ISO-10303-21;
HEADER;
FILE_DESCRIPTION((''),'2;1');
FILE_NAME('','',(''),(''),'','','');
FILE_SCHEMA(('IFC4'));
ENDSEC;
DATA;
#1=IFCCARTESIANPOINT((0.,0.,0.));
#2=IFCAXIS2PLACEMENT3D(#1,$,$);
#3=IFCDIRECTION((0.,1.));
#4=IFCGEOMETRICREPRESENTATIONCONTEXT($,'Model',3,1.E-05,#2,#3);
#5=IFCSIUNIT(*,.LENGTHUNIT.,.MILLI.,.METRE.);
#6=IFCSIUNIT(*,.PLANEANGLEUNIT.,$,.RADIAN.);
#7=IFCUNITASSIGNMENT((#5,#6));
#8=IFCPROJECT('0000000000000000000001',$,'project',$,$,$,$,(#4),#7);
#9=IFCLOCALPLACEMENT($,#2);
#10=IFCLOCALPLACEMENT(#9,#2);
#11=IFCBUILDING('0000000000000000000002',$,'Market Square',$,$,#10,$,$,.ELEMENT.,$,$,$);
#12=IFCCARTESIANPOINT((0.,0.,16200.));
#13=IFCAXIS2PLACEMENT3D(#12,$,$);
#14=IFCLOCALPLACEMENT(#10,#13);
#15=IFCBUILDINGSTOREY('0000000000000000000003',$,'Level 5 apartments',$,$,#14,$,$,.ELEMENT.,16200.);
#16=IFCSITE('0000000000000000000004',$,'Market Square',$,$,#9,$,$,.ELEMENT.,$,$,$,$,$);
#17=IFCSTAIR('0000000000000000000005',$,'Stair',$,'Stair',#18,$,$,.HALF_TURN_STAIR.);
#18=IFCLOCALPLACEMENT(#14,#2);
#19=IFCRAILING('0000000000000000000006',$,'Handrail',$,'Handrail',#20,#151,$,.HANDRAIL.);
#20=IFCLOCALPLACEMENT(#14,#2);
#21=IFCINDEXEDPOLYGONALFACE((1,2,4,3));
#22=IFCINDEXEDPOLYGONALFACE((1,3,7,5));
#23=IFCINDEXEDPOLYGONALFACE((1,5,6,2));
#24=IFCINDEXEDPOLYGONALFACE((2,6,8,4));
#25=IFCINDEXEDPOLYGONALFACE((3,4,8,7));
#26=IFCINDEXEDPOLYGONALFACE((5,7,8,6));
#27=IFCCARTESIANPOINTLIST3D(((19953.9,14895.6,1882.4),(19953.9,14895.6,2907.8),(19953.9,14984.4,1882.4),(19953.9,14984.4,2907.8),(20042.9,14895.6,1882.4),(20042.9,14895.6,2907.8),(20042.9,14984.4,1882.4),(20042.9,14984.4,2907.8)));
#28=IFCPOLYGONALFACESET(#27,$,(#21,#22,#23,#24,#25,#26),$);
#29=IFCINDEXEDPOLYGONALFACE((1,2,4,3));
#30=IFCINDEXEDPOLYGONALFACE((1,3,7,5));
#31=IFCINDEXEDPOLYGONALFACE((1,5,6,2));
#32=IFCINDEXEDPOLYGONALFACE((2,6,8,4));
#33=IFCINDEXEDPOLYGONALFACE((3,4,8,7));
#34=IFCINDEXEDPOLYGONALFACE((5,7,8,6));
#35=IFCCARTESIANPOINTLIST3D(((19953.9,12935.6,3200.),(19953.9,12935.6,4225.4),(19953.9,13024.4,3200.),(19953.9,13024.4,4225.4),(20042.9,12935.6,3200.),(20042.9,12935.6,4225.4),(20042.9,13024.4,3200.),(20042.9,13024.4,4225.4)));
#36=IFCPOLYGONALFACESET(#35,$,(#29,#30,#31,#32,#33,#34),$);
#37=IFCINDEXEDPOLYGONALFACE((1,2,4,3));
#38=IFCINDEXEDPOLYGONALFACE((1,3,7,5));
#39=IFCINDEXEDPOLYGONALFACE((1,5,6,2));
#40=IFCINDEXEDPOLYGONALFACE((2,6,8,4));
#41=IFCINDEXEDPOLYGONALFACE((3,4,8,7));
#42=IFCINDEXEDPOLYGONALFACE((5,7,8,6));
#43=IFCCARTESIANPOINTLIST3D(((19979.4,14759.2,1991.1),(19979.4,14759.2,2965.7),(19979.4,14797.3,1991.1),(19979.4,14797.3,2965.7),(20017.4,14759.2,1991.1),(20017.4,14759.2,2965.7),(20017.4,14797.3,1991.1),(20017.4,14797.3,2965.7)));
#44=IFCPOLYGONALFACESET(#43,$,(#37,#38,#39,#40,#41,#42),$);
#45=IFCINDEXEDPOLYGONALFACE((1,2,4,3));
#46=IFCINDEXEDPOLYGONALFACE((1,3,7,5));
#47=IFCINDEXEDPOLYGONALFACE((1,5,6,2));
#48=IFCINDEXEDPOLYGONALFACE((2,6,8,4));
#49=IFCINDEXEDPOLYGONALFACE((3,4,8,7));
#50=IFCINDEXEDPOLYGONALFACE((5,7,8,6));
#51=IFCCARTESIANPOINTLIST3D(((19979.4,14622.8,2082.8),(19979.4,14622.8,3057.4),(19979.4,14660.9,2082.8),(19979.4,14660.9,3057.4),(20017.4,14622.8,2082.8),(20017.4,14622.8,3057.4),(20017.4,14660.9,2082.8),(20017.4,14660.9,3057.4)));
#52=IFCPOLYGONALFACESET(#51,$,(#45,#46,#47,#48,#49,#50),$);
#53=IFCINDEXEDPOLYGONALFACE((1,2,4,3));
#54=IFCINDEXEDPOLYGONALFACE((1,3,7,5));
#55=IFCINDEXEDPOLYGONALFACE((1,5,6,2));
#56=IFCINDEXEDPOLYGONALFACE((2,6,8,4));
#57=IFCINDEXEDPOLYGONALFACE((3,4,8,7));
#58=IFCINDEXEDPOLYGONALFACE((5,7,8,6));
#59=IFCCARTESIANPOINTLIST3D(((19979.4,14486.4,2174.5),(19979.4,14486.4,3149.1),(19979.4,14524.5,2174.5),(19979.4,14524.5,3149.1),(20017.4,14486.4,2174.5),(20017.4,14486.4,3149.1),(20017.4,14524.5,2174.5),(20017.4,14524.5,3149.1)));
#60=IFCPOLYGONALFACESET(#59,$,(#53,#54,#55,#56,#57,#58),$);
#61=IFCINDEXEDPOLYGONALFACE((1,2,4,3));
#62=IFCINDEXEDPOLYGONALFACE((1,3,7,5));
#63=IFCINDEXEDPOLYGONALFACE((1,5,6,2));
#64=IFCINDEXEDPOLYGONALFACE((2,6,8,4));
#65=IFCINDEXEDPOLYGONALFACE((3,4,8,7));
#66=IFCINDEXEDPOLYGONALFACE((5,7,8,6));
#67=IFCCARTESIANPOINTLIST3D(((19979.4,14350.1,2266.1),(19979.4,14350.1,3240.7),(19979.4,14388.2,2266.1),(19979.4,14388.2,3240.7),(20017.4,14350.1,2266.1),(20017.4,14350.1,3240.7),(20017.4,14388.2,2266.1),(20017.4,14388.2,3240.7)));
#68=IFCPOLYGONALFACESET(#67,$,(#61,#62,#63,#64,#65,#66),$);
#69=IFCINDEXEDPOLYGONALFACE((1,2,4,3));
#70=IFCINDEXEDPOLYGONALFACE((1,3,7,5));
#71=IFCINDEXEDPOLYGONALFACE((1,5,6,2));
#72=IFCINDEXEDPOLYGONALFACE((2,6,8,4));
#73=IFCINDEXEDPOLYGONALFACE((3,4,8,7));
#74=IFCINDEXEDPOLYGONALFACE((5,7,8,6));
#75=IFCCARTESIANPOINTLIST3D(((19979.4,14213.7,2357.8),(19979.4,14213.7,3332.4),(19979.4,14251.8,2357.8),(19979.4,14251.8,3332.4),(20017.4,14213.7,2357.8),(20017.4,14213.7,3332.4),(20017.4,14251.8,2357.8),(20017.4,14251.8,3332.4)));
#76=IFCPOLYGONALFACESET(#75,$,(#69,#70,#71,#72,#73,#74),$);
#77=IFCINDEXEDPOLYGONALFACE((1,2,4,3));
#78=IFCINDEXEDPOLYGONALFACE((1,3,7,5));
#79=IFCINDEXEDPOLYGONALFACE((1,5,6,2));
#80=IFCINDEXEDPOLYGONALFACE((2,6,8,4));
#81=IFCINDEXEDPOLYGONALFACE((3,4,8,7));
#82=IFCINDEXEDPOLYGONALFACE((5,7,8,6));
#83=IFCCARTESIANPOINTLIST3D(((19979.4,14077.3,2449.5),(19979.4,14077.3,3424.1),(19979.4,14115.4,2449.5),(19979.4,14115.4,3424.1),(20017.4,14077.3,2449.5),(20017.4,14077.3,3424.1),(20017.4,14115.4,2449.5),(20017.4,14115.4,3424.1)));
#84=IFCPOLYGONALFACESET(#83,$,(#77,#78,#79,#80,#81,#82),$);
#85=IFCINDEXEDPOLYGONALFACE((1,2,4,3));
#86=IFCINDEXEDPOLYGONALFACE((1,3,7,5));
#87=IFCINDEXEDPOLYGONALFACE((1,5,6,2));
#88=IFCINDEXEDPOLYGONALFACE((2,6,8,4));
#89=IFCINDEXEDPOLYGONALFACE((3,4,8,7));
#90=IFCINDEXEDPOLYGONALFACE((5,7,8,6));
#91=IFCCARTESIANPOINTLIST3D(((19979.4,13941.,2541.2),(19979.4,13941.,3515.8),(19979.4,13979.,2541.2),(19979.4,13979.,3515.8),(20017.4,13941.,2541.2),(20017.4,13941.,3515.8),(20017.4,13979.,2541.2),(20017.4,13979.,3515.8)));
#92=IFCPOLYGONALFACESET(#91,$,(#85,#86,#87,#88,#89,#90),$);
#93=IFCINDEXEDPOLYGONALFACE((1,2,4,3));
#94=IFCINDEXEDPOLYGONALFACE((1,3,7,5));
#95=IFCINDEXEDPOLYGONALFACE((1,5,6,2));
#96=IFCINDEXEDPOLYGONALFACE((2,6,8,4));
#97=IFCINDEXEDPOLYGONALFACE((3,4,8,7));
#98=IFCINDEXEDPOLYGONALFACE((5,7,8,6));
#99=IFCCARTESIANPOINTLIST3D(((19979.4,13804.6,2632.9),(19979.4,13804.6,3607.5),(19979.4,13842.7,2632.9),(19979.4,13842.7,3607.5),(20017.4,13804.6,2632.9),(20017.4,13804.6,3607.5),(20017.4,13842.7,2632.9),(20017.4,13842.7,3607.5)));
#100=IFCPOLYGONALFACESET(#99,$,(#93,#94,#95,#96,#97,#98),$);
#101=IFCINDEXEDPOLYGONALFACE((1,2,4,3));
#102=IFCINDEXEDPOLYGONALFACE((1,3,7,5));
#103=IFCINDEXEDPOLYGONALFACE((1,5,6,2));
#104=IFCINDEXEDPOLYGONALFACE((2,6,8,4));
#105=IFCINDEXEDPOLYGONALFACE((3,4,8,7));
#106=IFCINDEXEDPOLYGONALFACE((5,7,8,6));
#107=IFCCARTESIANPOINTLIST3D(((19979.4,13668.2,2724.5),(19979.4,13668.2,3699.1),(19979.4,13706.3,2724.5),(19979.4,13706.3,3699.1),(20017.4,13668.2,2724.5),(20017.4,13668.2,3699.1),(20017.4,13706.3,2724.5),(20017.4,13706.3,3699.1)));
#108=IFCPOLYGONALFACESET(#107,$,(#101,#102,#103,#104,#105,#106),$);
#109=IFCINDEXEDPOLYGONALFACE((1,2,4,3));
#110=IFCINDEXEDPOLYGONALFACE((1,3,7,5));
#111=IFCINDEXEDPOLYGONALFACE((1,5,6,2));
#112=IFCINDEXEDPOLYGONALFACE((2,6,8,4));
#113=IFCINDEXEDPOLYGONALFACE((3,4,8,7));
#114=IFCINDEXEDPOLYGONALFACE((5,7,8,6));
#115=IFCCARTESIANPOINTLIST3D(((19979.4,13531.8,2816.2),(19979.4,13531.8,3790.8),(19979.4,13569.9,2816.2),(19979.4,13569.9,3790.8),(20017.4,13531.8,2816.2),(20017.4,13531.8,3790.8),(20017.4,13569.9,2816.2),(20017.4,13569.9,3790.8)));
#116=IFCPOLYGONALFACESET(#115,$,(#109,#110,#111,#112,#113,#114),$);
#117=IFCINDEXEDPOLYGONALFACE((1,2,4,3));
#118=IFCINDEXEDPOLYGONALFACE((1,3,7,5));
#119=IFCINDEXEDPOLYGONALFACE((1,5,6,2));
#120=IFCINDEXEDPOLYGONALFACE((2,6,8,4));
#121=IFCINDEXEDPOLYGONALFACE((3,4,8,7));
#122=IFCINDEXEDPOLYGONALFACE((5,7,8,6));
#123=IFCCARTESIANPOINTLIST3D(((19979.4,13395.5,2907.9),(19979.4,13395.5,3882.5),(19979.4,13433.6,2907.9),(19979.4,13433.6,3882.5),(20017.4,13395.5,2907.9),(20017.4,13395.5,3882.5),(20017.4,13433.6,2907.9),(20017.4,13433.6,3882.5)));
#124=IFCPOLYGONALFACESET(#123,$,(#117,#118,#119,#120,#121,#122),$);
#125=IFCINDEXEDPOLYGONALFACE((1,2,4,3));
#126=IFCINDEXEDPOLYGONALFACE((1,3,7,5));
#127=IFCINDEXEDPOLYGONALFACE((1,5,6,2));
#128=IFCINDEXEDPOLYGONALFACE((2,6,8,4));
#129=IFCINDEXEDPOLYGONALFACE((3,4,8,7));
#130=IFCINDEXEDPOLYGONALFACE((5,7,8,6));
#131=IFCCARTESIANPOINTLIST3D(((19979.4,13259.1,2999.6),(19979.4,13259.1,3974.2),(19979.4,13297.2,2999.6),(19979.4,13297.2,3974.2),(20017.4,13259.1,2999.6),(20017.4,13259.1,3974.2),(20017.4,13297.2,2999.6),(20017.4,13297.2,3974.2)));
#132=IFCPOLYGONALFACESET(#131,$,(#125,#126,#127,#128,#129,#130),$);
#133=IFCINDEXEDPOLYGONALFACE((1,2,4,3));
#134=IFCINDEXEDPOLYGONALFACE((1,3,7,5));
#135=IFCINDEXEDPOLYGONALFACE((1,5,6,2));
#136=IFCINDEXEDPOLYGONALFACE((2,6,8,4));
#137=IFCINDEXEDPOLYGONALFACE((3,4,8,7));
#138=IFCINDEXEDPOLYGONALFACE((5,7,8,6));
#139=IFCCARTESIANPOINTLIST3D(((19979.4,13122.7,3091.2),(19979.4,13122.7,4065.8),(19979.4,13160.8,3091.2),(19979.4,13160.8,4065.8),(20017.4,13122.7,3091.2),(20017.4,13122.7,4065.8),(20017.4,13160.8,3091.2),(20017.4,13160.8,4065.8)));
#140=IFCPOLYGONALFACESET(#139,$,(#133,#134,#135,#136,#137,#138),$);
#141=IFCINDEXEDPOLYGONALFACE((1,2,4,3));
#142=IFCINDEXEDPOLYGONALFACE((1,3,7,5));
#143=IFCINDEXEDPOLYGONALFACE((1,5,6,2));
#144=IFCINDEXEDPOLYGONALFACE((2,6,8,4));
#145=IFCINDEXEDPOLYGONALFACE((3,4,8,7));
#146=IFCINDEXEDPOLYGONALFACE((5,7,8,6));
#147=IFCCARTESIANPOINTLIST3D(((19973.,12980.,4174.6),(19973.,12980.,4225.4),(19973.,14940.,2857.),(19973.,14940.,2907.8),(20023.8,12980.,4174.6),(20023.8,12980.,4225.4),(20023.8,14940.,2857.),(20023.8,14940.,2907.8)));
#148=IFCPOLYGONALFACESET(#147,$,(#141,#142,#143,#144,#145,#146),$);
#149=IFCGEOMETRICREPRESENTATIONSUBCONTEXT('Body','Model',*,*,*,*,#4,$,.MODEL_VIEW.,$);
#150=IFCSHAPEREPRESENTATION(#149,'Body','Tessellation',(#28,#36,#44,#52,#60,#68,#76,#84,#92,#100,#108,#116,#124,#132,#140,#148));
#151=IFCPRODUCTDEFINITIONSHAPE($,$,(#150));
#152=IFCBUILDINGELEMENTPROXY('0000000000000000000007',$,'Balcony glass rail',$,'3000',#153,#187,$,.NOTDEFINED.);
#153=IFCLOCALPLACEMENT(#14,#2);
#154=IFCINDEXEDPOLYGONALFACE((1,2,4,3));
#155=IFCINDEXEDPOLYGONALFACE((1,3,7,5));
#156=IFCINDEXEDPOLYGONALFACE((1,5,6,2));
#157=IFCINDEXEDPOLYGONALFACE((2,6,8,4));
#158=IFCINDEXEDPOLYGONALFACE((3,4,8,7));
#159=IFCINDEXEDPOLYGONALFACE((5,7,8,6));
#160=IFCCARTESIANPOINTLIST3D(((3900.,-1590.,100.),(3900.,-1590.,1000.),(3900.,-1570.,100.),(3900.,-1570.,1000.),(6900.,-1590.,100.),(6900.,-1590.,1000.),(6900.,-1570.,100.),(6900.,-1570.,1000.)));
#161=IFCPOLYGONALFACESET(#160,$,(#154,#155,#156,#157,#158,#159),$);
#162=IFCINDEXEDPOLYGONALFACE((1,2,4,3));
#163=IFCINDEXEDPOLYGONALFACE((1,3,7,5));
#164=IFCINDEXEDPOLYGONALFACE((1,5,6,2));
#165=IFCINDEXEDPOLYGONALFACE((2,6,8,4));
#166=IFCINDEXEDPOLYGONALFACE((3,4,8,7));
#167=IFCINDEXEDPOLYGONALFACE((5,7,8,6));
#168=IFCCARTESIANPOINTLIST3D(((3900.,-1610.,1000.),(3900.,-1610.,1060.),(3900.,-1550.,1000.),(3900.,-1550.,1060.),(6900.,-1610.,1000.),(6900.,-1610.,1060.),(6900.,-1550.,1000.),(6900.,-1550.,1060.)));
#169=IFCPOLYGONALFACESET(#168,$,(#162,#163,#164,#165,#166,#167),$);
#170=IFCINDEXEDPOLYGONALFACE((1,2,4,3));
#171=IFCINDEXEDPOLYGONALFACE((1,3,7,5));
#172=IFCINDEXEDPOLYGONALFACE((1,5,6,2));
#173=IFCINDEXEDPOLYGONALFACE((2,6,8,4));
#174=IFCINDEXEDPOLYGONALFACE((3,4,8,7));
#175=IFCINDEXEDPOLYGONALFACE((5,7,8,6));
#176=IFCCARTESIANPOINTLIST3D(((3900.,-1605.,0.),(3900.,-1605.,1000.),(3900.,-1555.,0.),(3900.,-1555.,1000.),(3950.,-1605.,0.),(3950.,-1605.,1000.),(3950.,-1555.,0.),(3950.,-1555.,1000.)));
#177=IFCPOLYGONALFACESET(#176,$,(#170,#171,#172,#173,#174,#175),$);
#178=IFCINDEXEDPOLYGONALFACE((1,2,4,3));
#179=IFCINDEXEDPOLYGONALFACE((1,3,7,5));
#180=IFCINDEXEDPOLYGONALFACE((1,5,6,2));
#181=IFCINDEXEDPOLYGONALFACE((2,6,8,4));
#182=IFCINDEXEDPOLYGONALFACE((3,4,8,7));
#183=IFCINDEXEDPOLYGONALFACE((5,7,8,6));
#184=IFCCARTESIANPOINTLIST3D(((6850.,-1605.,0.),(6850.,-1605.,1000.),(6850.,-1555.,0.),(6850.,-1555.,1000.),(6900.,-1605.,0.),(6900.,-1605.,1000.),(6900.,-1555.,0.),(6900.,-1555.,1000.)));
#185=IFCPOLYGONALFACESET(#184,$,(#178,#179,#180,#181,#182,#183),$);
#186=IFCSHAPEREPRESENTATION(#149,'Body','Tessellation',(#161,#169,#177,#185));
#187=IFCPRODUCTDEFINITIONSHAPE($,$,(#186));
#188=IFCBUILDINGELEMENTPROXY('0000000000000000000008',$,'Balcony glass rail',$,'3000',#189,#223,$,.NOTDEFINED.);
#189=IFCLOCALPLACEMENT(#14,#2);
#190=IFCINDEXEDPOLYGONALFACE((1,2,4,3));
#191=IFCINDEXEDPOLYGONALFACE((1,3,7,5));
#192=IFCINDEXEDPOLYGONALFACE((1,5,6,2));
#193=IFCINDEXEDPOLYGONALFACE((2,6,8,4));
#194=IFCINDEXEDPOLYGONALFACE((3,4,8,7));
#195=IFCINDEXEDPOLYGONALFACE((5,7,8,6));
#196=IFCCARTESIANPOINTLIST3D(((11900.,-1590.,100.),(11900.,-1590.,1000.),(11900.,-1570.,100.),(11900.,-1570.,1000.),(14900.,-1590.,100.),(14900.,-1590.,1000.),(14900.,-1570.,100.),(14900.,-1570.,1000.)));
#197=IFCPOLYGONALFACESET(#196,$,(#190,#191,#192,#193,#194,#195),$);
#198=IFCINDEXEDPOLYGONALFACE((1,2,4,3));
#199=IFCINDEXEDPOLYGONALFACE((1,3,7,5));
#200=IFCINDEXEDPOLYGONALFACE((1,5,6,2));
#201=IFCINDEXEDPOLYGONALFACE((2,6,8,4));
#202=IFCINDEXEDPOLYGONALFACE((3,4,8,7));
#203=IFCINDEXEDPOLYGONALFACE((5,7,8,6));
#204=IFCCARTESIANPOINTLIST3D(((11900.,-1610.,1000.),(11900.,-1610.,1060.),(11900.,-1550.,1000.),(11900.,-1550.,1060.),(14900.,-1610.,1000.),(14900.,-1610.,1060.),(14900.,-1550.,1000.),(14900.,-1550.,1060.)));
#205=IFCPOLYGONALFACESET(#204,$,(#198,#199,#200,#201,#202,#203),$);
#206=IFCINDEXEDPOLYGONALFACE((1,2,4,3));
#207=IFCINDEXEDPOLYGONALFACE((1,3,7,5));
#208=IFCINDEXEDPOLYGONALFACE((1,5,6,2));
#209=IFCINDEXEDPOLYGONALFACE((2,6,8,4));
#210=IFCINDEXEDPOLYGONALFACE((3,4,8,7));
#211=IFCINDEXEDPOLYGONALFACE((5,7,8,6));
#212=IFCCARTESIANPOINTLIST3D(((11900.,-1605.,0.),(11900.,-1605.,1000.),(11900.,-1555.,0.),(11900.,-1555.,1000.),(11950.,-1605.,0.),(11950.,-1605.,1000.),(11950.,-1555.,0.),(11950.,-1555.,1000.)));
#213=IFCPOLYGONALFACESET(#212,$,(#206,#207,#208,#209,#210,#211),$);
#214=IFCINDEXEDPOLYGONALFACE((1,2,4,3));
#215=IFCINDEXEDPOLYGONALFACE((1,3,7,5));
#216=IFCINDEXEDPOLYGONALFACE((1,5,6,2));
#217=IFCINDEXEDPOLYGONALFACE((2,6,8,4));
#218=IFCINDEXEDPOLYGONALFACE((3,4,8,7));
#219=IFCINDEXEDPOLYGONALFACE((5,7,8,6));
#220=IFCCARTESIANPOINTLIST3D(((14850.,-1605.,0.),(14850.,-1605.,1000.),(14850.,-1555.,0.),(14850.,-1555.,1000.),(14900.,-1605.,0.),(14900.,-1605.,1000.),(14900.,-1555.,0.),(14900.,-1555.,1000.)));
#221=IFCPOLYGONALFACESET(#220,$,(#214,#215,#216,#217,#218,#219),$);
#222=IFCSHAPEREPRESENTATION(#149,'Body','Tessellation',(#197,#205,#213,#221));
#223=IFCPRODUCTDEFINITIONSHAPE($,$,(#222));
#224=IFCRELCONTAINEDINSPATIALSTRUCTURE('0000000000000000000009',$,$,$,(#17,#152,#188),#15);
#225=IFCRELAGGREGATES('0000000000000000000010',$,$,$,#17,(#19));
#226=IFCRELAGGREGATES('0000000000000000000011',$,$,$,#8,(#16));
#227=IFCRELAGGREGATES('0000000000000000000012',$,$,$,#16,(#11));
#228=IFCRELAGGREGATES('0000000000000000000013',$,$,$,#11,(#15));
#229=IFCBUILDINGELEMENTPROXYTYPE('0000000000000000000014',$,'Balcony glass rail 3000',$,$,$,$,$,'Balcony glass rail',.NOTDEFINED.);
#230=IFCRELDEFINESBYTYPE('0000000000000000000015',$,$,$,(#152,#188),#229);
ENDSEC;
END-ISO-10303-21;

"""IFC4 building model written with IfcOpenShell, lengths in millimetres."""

from ifc_helpers import new_model, si_unit, direction, frame, origin, origin_with_axes, place, context, subcontext, project, spatial, polyline, outline, extrude, source, transform, mapped, type_object, type_shapes, element, aggregate, save


model = new_model("IFC4")

# Units and contexts
model_context = context("Model", 3, precision=1e-05, world=origin(), true_north=direction((0.0, 1.0)))
body_context = subcontext(model_context, "Body", "Model", "MODEL_VIEW")
ifc_project = project(units=[si_unit("LENGTHUNIT", "METRE", prefix="MILLI"), si_unit("PLANEANGLEUNIT", "RADIAN")], contexts=[model_context])

# Site, building, storey
site_placement = place(None, origin())
site = spatial("IfcSite", under=ifc_project, at=site_placement, Name="Market Square", CompositionType="ELEMENT")
building_placement = place(site_placement, origin())
building = spatial("IfcBuilding", under=site, at=building_placement, Name="Market Square", CompositionType="ELEMENT")
storey_placement = place(building_placement, frame((0.0, 0.0, 16200.0)))
storey = spatial("IfcBuildingStorey", under=building, at=storey_placement, Name="Level 5 apartments", CompositionType="ELEMENT", Elevation=16200.0)

# Stair
stair_placement = place(storey_placement, origin_with_axes())
stair = element("IfcStair", 1, at=stair_placement, inside=storey, Name="Stair", ObjectType="Stair", PredefinedType="HALF_TURN_STAIR")

# Railing
railing_1_placement = place(storey_placement, origin_with_axes())
railing_1 = element("IfcRailing", 2, at=railing_1_placement, Name="Handrail", ObjectType="Handrail", PredefinedType="HANDRAIL", context=body_context, shape_type="SweptSolid", body=[
    extrude(outline(polyline([(-44.5, -44.5), (44.5, -44.5), (44.5, 44.5), (-44.5, 44.5), (-44.5, -44.5)])), frame((19998.4, 14940.0, 1882.4), z_axis=(0.0, 0.0, 1.0), x_axis=(1.0, 0.0, 0.0)), (0.0, 0.0, 1.0), 1025.4),
    extrude(outline(polyline([(-44.5, -44.5), (44.5, -44.5), (44.5, 44.5), (-44.5, 44.5), (-44.5, -44.5)])), frame((19998.4, 12980.0, 3200.0), z_axis=(0.0, 0.0, 1.0), x_axis=(1.0, 0.0, 0.0)), (0.0, 0.0, 1.0), 1025.4),
    extrude(outline(polyline([(-19.1, -19.1), (19.1, -19.1), (19.1, 19.1), (-19.1, 19.1), (-19.1, -19.1)])), frame((19998.4, 14778.2, 1991.1), z_axis=(0.0, 0.0, 1.0), x_axis=(1.0, 0.0, 0.0)), (0.0, 0.0, 1.0), 974.6),
    extrude(outline(polyline([(-19.1, -19.1), (19.1, -19.1), (19.1, 19.1), (-19.1, 19.1), (-19.1, -19.1)])), frame((19998.4, 14641.9, 2082.8), z_axis=(0.0, 0.0, 1.0), x_axis=(1.0, 0.0, 0.0)), (0.0, 0.0, 1.0), 974.6),
    extrude(outline(polyline([(-19.1, -19.1), (19.1, -19.1), (19.1, 19.1), (-19.1, 19.1), (-19.1, -19.1)])), frame((19998.4, 14505.5, 2174.5), z_axis=(0.0, 0.0, 1.0), x_axis=(1.0, 0.0, 0.0)), (0.0, 0.0, 1.0), 974.6),
    extrude(outline(polyline([(-19.1, -19.1), (19.1, -19.1), (19.1, 19.1), (-19.1, 19.1), (-19.1, -19.1)])), frame((19998.4, 14369.1, 2266.1), z_axis=(0.0, 0.0, 1.0), x_axis=(1.0, 0.0, 0.0)), (0.0, 0.0, 1.0), 974.6),
    extrude(outline(polyline([(-19.1, -19.1), (19.1, -19.1), (19.1, 19.1), (-19.1, 19.1), (-19.1, -19.1)])), frame((19998.4, 14232.7, 2357.8), z_axis=(0.0, 0.0, 1.0), x_axis=(1.0, 0.0, 0.0)), (0.0, 0.0, 1.0), 974.6),
    extrude(outline(polyline([(-19.1, -19.1), (19.1, -19.1), (19.1, 19.1), (-19.1, 19.1), (-19.1, -19.1)])), frame((19998.4, 14096.4, 2449.5), z_axis=(0.0, 0.0, 1.0), x_axis=(1.0, 0.0, 0.0)), (0.0, 0.0, 1.0), 974.6),
    extrude(outline(polyline([(-19.1, -19.1), (19.1, -19.1), (19.1, 19.1), (-19.1, 19.1), (-19.1, -19.1)])), frame((19998.4, 13960.0, 2541.2), z_axis=(0.0, 0.0, 1.0), x_axis=(1.0, 0.0, 0.0)), (0.0, 0.0, 1.0), 974.6),
    extrude(outline(polyline([(-19.1, -19.1), (19.1, -19.1), (19.1, 19.1), (-19.1, 19.1), (-19.1, -19.1)])), frame((19998.4, 13823.6, 2632.9), z_axis=(0.0, 0.0, 1.0), x_axis=(1.0, 0.0, 0.0)), (0.0, 0.0, 1.0), 974.6),
    extrude(outline(polyline([(-19.1, -19.1), (19.1, -19.1), (19.1, 19.1), (-19.1, 19.1), (-19.1, -19.1)])), frame((19998.4, 13687.3, 2724.5), z_axis=(0.0, 0.0, 1.0), x_axis=(1.0, 0.0, 0.0)), (0.0, 0.0, 1.0), 974.6),
    extrude(outline(polyline([(-19.1, -19.1), (19.1, -19.1), (19.1, 19.1), (-19.1, 19.1), (-19.1, -19.1)])), frame((19998.4, 13550.9, 2816.2), z_axis=(0.0, 0.0, 1.0), x_axis=(1.0, 0.0, 0.0)), (0.0, 0.0, 1.0), 974.6),
    extrude(outline(polyline([(-19.1, -19.1), (19.1, -19.1), (19.1, 19.1), (-19.1, 19.1), (-19.1, -19.1)])), frame((19998.4, 13414.5, 2907.9), z_axis=(0.0, 0.0, 1.0), x_axis=(1.0, 0.0, 0.0)), (0.0, 0.0, 1.0), 974.6),
    extrude(outline(polyline([(-19.1, -19.1), (19.1, -19.1), (19.1, 19.1), (-19.1, 19.1), (-19.1, -19.1)])), frame((19998.4, 13278.1, 2999.6), z_axis=(0.0, 0.0, 1.0), x_axis=(1.0, 0.0, 0.0)), (0.0, 0.0, 1.0), 974.6),
    extrude(outline(polyline([(-19.1, -19.1), (19.1, -19.1), (19.1, 19.1), (-19.1, 19.1), (-19.1, -19.1)])), frame((19998.4, 13141.8, 3091.2), z_axis=(0.0, 0.0, 1.0), x_axis=(1.0, 0.0, 0.0)), (0.0, 0.0, 1.0), 974.6),
    extrude(outline(polyline([(0.0, 0.0), (50.8, 0.0), (50.8, 50.8), (0.0, 50.8), (0.0, 0.0)])), frame((19973.0, 14940.0, 2857.0), z_axis=(0.0, -1.0, 0.0), x_axis=(1.0, 0.0, 0.0)), (0.0, 0.557915, 0.829898), 2361.7),
])
aggregate(stair, [railing_1])

# Building element proxies
building_element_proxy_type = type_object("IfcBuildingElementProxyType", Name="Balcony glass rail 3000", ElementType="Balcony glass rail", PredefinedType="NOTDEFINED")
shared_shape = source(origin(), body_context, "Body", "SweptSolid", [
    extrude(outline(polyline([(0.0, -10.0), (3000.0, -10.0), (3000.0, 10.0), (0.0, 10.0), (0.0, -10.0)])), frame((0.0, 0.0, 100.0)), (0.0, 0.0, 1.0), 900.0),
    extrude(outline(polyline([(0.0, -30.0), (3000.0, -30.0), (3000.0, 30.0), (0.0, 30.0), (0.0, -30.0)])), frame((0.0, 0.0, 1000.0)), (0.0, 0.0, 1.0), 60.0),
    extrude(outline(polyline([(0.0, -25.0), (50.0, -25.0), (50.0, 25.0), (0.0, 25.0), (0.0, -25.0)])), origin(), (0.0, 0.0, 1.0), 1000.0),
    extrude(outline(polyline([(2950.0, -25.0), (3000.0, -25.0), (3000.0, 25.0), (2950.0, 25.0), (2950.0, -25.0)])), origin(), (0.0, 0.0, 1.0), 1000.0),
])
type_shapes(building_element_proxy_type, [shared_shape])
for number, where, z_axis, x_axis, name in (
    (3, (3900.0, -1580.0, 0.0), (0.0, 0.0, 1.0), (1.0, 0.0, 0.0), "Balcony glass rail"),
    (4, (11900.0, -1580.0, 0.0), (0.0, 0.0, 1.0), (1.0, 0.0, 0.0), "Balcony glass rail"),
):
    element("IfcBuildingElementProxy", number, at=place(storey_placement, frame(where, z_axis=z_axis, x_axis=x_axis)), inside=storey, type_object=building_element_proxy_type, Name=name, ObjectType="3000", PredefinedType="NOTDEFINED", context=body_context, shape_type="MappedRepresentation", body=[
        mapped(shared_shape, transform((0.0, 0.0, 0.0))),
    ])

save(model, "model.ifc")
